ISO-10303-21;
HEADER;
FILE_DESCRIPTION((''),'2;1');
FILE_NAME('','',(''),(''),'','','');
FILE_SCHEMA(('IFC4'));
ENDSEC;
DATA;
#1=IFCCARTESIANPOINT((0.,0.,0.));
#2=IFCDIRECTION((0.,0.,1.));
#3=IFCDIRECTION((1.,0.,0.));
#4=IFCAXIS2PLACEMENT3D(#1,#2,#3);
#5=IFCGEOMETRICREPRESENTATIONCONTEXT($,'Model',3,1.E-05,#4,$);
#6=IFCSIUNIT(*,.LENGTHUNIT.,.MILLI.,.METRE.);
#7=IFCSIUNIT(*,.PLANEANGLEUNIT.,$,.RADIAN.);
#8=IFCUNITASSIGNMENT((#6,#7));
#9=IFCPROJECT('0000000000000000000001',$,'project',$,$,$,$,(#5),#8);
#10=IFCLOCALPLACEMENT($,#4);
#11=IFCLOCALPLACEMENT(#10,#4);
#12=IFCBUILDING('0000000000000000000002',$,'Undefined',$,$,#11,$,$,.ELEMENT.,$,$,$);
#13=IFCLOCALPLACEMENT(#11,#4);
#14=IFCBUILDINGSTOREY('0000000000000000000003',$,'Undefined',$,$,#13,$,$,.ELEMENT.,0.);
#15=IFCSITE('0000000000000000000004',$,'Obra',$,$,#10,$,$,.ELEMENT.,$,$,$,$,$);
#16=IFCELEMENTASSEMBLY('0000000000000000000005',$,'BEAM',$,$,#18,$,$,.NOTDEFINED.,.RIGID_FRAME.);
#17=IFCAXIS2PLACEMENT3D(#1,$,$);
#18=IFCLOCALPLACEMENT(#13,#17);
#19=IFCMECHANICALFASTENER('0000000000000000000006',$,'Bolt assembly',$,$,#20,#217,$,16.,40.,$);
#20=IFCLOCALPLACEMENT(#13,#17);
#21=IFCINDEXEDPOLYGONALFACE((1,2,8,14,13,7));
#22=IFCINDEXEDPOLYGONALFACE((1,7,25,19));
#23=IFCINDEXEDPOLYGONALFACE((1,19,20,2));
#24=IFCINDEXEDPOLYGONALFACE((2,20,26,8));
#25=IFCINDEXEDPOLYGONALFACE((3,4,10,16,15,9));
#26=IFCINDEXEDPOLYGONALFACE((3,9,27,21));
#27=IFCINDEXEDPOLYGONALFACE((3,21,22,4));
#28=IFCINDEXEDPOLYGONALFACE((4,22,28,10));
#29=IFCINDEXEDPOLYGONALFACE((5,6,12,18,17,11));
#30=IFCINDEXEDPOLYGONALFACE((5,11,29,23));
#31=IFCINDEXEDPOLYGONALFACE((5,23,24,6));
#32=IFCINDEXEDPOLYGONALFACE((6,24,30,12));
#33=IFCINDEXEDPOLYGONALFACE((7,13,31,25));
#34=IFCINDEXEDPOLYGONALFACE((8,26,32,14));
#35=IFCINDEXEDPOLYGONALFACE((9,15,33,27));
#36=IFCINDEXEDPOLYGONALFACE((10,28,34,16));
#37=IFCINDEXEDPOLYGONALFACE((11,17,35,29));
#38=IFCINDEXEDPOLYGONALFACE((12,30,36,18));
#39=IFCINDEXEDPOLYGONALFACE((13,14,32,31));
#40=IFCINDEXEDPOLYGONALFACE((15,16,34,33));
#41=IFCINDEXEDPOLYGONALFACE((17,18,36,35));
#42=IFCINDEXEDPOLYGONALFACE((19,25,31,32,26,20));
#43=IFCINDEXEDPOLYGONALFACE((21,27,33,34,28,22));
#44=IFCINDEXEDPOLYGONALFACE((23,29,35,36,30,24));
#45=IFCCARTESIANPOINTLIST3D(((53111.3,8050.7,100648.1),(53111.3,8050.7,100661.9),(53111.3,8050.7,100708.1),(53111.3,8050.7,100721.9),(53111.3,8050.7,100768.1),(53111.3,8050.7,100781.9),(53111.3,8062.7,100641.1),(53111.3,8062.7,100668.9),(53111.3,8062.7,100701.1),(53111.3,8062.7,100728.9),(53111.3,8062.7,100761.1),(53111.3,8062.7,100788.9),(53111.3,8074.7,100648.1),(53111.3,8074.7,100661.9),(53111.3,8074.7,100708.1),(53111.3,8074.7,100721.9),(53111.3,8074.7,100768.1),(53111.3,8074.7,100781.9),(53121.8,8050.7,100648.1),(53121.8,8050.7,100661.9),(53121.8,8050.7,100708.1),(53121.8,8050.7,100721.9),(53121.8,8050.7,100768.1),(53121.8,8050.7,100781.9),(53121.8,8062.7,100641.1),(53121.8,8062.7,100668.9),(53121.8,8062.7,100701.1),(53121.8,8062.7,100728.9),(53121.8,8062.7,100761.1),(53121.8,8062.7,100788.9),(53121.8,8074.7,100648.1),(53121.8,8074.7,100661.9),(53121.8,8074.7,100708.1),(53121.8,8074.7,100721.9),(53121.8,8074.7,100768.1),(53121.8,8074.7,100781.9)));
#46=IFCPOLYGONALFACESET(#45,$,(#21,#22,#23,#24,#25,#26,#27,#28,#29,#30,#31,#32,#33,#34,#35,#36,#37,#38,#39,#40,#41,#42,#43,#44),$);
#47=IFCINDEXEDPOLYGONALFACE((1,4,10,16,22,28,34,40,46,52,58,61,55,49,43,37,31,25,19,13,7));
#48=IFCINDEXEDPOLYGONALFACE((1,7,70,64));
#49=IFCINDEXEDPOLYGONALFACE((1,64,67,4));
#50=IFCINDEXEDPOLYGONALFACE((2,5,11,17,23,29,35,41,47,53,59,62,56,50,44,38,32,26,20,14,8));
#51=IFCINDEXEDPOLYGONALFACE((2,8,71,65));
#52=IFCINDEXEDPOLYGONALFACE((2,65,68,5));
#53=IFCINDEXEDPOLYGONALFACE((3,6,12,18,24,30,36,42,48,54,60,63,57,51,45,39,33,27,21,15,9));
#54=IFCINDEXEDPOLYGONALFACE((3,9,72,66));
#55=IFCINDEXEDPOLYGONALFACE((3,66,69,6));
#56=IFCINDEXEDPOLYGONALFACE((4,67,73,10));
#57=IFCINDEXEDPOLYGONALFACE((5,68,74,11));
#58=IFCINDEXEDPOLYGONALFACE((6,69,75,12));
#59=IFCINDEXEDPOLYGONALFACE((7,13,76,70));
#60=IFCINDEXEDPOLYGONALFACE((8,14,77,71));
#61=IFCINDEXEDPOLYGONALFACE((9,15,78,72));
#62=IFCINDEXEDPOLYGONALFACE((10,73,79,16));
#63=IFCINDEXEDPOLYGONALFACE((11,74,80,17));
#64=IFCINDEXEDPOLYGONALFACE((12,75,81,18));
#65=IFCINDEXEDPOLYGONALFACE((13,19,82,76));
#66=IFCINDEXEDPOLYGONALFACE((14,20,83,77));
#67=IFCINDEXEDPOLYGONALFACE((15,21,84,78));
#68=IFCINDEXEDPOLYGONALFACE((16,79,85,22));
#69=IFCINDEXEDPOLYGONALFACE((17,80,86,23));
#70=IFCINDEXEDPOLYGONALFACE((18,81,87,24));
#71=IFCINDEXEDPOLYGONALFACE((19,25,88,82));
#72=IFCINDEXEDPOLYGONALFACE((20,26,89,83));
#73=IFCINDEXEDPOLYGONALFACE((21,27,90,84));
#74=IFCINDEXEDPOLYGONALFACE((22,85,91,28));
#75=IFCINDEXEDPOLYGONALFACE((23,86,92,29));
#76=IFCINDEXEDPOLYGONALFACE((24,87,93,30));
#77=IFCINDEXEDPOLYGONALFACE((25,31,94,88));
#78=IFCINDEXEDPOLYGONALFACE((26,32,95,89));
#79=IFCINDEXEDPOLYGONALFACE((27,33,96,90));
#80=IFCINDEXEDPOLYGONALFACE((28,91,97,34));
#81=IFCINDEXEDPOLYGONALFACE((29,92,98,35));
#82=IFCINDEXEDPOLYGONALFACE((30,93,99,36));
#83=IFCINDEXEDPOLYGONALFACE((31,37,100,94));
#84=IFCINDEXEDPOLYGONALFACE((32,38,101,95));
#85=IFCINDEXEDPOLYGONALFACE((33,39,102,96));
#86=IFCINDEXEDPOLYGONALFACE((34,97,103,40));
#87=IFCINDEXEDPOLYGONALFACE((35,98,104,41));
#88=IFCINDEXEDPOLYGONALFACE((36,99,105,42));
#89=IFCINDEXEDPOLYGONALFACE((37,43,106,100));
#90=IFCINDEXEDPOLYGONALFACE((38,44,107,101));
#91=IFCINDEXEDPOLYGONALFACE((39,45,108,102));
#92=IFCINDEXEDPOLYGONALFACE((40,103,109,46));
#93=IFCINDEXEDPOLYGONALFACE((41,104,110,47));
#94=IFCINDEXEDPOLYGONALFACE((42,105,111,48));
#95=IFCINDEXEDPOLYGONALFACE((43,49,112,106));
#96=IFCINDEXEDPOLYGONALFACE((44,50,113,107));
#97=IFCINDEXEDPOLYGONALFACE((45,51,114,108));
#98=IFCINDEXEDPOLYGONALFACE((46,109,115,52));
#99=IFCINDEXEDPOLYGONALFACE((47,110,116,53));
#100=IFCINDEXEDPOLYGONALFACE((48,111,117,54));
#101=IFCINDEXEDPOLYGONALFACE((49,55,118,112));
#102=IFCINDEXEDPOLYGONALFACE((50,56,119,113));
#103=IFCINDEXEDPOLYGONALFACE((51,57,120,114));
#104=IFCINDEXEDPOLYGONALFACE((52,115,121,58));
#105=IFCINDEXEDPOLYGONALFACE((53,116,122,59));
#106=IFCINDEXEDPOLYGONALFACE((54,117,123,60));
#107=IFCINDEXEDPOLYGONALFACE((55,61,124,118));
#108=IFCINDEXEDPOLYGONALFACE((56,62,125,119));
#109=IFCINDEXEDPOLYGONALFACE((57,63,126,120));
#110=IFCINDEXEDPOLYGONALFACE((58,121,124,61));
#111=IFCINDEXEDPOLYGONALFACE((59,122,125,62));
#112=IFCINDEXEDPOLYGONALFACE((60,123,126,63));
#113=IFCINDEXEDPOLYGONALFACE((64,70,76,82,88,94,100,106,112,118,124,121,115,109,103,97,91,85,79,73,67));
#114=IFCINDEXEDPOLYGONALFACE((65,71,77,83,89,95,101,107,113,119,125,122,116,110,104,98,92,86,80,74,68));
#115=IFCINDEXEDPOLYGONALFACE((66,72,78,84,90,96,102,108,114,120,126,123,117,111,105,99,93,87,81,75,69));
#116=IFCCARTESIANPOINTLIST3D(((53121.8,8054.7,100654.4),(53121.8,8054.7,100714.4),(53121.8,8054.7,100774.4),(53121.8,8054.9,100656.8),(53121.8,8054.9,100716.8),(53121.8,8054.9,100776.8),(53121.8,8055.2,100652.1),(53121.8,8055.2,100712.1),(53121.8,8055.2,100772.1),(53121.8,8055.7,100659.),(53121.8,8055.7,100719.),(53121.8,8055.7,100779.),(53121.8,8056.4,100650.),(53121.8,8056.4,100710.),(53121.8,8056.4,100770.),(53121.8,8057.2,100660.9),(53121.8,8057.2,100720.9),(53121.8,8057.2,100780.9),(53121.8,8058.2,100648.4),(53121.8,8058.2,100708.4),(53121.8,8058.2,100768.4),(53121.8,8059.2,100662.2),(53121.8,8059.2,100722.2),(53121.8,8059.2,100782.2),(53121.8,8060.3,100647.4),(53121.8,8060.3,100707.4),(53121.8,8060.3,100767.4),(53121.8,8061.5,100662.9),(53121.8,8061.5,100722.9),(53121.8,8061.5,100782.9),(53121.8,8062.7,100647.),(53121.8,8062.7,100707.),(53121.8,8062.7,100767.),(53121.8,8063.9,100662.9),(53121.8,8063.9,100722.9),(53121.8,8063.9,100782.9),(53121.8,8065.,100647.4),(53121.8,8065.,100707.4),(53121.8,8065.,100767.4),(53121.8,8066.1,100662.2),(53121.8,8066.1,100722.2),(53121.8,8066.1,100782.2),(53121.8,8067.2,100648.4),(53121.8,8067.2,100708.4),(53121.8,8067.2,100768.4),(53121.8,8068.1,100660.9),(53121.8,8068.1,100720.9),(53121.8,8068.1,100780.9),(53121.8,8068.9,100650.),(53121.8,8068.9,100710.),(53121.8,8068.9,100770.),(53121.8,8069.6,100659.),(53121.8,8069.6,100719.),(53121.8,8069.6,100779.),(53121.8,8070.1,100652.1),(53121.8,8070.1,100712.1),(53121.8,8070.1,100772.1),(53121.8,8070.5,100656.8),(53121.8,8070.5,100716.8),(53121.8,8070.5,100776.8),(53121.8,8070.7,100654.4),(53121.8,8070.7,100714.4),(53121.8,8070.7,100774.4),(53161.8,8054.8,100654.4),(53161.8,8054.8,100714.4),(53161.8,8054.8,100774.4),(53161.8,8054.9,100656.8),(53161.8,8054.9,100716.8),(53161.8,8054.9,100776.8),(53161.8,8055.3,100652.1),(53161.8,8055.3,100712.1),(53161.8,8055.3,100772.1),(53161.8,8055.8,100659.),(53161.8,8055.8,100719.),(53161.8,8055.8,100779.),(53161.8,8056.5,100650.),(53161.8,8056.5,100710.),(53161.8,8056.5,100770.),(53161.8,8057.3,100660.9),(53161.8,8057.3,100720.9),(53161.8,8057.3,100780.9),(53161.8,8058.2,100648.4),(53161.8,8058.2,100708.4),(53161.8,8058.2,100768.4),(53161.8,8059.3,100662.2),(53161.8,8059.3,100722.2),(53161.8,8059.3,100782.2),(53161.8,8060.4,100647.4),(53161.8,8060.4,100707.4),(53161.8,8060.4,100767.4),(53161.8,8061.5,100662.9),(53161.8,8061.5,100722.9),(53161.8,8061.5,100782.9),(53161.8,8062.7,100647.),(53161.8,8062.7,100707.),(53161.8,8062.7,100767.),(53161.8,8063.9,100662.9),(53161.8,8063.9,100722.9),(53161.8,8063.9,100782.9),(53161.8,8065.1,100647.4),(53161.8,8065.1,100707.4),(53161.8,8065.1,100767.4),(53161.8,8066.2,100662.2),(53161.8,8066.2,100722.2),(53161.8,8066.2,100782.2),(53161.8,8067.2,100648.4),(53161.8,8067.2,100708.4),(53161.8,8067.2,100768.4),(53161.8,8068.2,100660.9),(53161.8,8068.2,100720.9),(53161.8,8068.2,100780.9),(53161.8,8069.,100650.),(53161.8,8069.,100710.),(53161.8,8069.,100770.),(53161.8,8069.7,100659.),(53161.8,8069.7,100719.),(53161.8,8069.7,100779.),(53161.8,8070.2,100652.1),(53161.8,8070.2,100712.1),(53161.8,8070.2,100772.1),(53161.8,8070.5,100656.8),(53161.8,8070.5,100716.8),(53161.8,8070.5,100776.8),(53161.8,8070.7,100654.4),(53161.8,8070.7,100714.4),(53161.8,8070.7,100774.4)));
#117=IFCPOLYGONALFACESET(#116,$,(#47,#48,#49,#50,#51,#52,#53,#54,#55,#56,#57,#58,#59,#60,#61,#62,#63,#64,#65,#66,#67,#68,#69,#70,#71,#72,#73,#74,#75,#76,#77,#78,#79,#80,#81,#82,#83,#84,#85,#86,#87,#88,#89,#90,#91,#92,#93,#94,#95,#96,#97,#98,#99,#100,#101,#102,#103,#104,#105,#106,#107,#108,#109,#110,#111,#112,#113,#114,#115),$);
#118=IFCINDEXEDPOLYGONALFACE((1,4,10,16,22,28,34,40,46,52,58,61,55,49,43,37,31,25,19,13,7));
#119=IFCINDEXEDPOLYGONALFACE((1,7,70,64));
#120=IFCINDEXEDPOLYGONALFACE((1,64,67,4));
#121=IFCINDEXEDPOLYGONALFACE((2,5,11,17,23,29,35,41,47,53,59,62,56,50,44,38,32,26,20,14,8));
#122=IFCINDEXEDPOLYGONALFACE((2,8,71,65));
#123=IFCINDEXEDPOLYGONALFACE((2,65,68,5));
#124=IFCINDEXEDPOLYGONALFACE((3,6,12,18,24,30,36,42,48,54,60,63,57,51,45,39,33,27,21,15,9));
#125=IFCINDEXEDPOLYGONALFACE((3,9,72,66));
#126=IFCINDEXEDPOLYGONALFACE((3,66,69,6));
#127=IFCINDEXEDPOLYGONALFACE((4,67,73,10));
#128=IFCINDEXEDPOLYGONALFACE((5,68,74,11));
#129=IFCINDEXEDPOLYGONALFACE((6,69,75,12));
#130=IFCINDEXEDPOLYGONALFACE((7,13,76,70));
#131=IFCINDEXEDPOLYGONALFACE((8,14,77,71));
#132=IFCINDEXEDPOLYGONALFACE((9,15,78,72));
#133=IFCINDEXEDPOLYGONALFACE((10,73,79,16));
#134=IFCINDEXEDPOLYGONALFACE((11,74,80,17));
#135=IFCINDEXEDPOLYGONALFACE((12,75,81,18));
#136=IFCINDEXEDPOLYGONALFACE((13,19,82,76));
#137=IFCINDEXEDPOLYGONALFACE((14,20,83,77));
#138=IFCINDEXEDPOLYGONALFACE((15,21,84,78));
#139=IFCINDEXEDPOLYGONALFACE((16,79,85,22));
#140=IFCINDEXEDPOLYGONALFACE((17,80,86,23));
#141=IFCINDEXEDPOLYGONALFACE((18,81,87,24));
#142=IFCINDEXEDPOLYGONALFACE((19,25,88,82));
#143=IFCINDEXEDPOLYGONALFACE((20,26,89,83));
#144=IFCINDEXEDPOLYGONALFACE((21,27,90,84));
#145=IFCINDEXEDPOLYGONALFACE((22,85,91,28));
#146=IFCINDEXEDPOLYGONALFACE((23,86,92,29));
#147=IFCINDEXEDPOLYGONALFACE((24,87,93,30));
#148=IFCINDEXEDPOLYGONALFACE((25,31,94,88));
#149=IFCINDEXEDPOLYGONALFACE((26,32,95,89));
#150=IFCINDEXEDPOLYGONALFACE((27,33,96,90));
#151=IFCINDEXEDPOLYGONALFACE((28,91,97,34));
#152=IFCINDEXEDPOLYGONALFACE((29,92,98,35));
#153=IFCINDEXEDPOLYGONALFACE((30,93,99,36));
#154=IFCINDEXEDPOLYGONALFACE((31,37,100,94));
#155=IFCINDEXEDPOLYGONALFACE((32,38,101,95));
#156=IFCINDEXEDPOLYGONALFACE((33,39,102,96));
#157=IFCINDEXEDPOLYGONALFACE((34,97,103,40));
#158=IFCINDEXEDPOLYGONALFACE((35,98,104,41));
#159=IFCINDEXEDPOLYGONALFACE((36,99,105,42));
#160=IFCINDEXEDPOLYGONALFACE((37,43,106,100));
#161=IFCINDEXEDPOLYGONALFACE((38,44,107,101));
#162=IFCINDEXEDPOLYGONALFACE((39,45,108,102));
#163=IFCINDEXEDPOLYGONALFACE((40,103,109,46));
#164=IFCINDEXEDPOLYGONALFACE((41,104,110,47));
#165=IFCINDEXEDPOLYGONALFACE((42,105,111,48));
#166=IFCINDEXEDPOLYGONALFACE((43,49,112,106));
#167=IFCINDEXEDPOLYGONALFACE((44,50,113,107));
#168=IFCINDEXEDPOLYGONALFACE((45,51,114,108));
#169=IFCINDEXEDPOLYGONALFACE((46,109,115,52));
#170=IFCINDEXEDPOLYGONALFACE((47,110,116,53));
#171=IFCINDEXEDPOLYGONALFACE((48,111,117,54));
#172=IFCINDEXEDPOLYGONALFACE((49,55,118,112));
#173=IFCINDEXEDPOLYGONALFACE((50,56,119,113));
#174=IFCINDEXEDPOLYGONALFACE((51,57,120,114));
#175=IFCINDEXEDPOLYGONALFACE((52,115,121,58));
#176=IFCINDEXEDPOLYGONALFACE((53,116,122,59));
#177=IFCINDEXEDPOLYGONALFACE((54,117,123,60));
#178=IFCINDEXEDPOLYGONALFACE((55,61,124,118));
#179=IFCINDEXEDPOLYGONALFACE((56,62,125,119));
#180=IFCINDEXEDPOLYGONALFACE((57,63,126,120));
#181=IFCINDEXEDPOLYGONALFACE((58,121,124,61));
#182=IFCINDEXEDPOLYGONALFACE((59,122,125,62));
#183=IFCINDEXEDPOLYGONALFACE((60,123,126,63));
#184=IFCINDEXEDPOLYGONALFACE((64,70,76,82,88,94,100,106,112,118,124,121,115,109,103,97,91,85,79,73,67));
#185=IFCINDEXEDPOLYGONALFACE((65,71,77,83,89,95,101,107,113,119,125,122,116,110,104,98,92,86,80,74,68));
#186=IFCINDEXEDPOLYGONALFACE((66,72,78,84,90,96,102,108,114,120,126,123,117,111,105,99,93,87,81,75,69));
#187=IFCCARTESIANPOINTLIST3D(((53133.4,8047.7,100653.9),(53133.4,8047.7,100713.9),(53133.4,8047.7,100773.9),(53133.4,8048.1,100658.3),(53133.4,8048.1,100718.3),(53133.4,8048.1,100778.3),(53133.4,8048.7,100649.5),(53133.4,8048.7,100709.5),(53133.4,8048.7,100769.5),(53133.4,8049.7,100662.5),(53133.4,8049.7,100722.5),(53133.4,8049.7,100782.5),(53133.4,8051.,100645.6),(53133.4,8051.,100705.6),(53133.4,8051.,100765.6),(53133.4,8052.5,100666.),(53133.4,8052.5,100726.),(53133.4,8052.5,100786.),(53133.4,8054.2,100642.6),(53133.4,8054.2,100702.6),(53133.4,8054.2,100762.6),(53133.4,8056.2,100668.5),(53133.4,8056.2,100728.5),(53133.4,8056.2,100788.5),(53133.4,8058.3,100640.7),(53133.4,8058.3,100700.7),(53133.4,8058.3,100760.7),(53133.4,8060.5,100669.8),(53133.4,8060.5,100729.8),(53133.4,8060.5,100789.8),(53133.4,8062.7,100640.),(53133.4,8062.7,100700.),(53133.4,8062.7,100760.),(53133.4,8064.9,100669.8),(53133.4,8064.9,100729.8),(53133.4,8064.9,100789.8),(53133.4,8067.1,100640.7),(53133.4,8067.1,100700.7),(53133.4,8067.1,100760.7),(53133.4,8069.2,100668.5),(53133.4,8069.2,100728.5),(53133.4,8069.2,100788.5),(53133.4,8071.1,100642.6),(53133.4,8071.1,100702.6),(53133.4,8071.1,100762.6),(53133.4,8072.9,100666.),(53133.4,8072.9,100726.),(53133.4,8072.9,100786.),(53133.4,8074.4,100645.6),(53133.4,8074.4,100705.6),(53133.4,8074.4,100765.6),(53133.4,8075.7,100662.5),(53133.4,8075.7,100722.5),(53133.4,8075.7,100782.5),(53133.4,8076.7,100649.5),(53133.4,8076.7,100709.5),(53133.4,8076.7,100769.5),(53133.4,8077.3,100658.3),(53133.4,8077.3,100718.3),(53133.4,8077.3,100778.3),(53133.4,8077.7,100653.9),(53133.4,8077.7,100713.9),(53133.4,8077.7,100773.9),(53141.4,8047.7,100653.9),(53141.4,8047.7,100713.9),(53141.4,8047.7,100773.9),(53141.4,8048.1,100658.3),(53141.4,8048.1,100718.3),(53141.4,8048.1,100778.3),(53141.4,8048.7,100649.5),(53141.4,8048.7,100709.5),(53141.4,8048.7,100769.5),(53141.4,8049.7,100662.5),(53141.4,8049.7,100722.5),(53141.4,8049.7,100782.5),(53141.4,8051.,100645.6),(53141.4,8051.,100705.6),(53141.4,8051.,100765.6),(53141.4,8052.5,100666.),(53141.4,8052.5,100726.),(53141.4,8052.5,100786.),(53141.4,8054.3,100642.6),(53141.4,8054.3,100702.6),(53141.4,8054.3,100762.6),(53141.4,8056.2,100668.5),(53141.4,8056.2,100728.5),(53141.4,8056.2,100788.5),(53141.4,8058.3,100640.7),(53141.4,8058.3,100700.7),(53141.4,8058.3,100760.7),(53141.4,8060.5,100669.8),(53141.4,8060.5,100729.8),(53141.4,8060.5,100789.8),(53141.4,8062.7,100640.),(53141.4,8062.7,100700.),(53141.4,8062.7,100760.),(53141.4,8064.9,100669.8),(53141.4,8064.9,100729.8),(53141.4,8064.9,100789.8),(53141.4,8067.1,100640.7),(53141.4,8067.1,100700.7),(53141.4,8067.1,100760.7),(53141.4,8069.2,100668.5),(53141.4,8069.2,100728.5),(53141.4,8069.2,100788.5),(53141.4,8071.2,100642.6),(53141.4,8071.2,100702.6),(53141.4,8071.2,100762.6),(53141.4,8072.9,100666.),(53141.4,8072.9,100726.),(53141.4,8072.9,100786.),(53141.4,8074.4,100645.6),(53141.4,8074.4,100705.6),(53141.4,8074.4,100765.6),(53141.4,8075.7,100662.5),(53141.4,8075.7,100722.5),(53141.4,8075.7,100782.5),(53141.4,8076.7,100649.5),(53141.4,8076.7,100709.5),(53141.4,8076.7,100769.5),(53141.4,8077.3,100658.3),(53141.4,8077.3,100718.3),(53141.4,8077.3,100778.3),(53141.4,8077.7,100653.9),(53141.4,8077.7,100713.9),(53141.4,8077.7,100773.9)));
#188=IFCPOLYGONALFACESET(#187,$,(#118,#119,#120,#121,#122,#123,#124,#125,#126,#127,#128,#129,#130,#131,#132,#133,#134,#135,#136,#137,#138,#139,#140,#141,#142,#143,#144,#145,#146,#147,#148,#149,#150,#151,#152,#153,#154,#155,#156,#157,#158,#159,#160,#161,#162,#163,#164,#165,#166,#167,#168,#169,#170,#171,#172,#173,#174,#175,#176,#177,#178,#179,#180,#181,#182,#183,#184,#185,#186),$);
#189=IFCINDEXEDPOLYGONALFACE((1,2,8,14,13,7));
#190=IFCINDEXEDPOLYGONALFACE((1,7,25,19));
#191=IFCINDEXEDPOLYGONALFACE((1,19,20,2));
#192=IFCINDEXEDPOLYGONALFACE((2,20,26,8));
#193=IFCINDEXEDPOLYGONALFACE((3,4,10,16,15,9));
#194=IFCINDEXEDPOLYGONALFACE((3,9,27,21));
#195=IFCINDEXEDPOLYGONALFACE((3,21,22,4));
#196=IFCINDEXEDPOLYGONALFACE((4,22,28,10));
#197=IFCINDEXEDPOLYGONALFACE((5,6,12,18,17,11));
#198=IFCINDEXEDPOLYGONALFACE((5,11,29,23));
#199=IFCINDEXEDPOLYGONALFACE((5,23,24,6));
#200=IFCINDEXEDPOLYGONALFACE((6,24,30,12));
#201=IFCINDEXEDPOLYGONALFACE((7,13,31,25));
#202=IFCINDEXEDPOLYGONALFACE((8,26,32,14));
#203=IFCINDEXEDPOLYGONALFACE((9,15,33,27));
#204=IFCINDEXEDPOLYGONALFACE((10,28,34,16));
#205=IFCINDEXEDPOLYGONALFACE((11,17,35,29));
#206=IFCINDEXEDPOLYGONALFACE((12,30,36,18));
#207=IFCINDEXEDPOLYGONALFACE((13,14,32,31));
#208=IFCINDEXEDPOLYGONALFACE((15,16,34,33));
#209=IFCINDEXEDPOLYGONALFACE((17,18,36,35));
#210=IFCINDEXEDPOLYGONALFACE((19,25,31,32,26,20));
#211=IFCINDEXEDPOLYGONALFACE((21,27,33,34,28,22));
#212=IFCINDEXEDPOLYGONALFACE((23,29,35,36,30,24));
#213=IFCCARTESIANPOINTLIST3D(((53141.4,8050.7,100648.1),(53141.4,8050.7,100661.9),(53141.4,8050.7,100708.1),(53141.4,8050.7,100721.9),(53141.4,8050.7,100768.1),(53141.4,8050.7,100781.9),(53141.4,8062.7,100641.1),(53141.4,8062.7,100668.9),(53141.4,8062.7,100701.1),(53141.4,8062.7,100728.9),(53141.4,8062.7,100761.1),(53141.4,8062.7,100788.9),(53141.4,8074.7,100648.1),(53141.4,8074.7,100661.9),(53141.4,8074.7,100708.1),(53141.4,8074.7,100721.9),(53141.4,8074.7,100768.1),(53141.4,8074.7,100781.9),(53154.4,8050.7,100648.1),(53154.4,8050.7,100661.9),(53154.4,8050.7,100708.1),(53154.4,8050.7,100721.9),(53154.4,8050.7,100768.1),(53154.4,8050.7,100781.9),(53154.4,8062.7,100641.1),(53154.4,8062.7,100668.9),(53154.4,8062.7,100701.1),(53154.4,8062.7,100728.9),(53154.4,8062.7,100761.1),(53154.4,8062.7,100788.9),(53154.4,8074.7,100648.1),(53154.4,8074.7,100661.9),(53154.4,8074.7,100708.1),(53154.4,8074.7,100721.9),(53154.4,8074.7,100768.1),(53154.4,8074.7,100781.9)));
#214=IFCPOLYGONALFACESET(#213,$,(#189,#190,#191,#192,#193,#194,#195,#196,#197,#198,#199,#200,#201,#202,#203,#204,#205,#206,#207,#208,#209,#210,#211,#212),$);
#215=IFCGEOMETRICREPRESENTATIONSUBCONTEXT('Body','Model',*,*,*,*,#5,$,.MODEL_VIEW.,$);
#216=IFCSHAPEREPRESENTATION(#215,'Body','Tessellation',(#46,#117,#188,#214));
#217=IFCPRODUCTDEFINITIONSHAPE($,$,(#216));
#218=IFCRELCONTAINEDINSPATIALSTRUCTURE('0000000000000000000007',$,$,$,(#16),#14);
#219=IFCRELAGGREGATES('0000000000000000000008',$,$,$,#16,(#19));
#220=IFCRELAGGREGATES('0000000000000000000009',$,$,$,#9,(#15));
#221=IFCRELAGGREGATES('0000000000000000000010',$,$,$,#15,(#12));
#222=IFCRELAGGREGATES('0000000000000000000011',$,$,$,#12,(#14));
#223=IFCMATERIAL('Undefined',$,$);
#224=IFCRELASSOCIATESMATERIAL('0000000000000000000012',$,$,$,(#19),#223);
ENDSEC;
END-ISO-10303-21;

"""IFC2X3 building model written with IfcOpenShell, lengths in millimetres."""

from ifc_helpers import new_model, si_unit, frame, origin_with_axes, origin_2d_with_axis, place, context, subcontext, project, spatial, polyline, circle, outline, extrude, source, transform, mapped, material, element, aggregate, save


model = new_model("IFC2X3")

# Units and contexts
model_context = context("Model", 3, precision=1e-05, world=origin_with_axes())
body_context = subcontext(model_context, "Body", "Model", "MODEL_VIEW")
ifc_project = project(units=[si_unit("LENGTHUNIT", "METRE", prefix="MILLI"), si_unit("PLANEANGLEUNIT", "RADIAN")], contexts=[model_context])

# Site, building, storey
site_placement = place(None, origin_with_axes())
site = spatial("IfcSite", under=ifc_project, at=site_placement, Name="Obra", CompositionType="ELEMENT")
building_placement = place(site_placement, origin_with_axes())
building = spatial("IfcBuilding", under=site, at=building_placement, Name="Undefined", CompositionType="ELEMENT")
storey_placement = place(building_placement, origin_with_axes())
storey = spatial("IfcBuildingStorey", under=building, at=storey_placement, Name="Undefined", CompositionType="ELEMENT", Elevation=0.0)

# Shared definitions
ifc_material_1 = material(Name="Undefined")

# Element assembly
assembly_1_placement = place(storey_placement, origin_with_axes())
assembly_1 = element("IfcElementAssembly", 1, at=assembly_1_placement, inside=storey, Name="BEAM", AssemblyPlace="NOTDEFINED", PredefinedType="RIGID_FRAME")

# Mechanical fastener
shared_shape_1 = source(origin_with_axes(), body_context, "Body", "SweptSolid", [
    extrude(outline(polyline([(13.9, 0.0), (6.9, 12.0), (-6.9, 12.0), (-13.9, 0.0), (-6.9, -12.0), (6.9, -12.0), (13.9, 0.0)])), frame((0.0, -19.7, 0.0), z_axis=(0.0, 1.0, 0.0), x_axis=(1.0, 0.0, 0.0)), (0.0, 0.0, 1.0), 10.6),
    extrude(circle(Radius=8.0, at=origin_2d_with_axis()), frame((0.0, -9.1, 0.0), z_axis=(0.0, 1.0, 0.0), x_axis=(1.0, 0.0, 0.0)), (0.0, 0.0, 1.0), 40.0),
    extrude(circle(Radius=15.0, at=origin_2d_with_axis()), frame((0.0, 2.5, 0.0), z_axis=(0.0, 1.0, 0.0), x_axis=(1.0, 0.0, 0.0)), (0.0, 0.0, 1.0), 8.0),
    extrude(outline(polyline([(13.9, 0.0), (6.9, 12.0), (-6.9, 12.0), (-13.9, 0.0), (-6.9, -12.0), (6.9, -12.0), (13.9, 0.0)])), frame((0.0, 10.5, 0.0), z_axis=(0.0, 1.0, 0.0), x_axis=(1.0, 0.0, 0.0)), (0.0, 0.0, 1.0), 13.0),
])
mechanical_fastener_1_placement = place(assembly_1_placement, frame((53130.9, 8112.7, 100835.0), z_axis=(0.001508, -0.999999, 0.0), x_axis=(0.0, 0.0, -1.0)))
mechanical_fastener_1 = element("IfcMechanicalFastener", 2, at=mechanical_fastener_1_placement, material=ifc_material_1, Name="Bolt assembly", NominalDiameter=16.0, NominalLength=40.0, context=body_context, shape_type="MappedRepresentation", body=[
    mapped(shared_shape_1, transform((60.0, 0.0, 50.0))),
    mapped(shared_shape_1, transform((120.0, 0.0, 50.0))),
    mapped(shared_shape_1, transform((180.0, 0.0, 50.0))),
])
aggregate(assembly_1, [mechanical_fastener_1])

save(model, "model.ifc")
